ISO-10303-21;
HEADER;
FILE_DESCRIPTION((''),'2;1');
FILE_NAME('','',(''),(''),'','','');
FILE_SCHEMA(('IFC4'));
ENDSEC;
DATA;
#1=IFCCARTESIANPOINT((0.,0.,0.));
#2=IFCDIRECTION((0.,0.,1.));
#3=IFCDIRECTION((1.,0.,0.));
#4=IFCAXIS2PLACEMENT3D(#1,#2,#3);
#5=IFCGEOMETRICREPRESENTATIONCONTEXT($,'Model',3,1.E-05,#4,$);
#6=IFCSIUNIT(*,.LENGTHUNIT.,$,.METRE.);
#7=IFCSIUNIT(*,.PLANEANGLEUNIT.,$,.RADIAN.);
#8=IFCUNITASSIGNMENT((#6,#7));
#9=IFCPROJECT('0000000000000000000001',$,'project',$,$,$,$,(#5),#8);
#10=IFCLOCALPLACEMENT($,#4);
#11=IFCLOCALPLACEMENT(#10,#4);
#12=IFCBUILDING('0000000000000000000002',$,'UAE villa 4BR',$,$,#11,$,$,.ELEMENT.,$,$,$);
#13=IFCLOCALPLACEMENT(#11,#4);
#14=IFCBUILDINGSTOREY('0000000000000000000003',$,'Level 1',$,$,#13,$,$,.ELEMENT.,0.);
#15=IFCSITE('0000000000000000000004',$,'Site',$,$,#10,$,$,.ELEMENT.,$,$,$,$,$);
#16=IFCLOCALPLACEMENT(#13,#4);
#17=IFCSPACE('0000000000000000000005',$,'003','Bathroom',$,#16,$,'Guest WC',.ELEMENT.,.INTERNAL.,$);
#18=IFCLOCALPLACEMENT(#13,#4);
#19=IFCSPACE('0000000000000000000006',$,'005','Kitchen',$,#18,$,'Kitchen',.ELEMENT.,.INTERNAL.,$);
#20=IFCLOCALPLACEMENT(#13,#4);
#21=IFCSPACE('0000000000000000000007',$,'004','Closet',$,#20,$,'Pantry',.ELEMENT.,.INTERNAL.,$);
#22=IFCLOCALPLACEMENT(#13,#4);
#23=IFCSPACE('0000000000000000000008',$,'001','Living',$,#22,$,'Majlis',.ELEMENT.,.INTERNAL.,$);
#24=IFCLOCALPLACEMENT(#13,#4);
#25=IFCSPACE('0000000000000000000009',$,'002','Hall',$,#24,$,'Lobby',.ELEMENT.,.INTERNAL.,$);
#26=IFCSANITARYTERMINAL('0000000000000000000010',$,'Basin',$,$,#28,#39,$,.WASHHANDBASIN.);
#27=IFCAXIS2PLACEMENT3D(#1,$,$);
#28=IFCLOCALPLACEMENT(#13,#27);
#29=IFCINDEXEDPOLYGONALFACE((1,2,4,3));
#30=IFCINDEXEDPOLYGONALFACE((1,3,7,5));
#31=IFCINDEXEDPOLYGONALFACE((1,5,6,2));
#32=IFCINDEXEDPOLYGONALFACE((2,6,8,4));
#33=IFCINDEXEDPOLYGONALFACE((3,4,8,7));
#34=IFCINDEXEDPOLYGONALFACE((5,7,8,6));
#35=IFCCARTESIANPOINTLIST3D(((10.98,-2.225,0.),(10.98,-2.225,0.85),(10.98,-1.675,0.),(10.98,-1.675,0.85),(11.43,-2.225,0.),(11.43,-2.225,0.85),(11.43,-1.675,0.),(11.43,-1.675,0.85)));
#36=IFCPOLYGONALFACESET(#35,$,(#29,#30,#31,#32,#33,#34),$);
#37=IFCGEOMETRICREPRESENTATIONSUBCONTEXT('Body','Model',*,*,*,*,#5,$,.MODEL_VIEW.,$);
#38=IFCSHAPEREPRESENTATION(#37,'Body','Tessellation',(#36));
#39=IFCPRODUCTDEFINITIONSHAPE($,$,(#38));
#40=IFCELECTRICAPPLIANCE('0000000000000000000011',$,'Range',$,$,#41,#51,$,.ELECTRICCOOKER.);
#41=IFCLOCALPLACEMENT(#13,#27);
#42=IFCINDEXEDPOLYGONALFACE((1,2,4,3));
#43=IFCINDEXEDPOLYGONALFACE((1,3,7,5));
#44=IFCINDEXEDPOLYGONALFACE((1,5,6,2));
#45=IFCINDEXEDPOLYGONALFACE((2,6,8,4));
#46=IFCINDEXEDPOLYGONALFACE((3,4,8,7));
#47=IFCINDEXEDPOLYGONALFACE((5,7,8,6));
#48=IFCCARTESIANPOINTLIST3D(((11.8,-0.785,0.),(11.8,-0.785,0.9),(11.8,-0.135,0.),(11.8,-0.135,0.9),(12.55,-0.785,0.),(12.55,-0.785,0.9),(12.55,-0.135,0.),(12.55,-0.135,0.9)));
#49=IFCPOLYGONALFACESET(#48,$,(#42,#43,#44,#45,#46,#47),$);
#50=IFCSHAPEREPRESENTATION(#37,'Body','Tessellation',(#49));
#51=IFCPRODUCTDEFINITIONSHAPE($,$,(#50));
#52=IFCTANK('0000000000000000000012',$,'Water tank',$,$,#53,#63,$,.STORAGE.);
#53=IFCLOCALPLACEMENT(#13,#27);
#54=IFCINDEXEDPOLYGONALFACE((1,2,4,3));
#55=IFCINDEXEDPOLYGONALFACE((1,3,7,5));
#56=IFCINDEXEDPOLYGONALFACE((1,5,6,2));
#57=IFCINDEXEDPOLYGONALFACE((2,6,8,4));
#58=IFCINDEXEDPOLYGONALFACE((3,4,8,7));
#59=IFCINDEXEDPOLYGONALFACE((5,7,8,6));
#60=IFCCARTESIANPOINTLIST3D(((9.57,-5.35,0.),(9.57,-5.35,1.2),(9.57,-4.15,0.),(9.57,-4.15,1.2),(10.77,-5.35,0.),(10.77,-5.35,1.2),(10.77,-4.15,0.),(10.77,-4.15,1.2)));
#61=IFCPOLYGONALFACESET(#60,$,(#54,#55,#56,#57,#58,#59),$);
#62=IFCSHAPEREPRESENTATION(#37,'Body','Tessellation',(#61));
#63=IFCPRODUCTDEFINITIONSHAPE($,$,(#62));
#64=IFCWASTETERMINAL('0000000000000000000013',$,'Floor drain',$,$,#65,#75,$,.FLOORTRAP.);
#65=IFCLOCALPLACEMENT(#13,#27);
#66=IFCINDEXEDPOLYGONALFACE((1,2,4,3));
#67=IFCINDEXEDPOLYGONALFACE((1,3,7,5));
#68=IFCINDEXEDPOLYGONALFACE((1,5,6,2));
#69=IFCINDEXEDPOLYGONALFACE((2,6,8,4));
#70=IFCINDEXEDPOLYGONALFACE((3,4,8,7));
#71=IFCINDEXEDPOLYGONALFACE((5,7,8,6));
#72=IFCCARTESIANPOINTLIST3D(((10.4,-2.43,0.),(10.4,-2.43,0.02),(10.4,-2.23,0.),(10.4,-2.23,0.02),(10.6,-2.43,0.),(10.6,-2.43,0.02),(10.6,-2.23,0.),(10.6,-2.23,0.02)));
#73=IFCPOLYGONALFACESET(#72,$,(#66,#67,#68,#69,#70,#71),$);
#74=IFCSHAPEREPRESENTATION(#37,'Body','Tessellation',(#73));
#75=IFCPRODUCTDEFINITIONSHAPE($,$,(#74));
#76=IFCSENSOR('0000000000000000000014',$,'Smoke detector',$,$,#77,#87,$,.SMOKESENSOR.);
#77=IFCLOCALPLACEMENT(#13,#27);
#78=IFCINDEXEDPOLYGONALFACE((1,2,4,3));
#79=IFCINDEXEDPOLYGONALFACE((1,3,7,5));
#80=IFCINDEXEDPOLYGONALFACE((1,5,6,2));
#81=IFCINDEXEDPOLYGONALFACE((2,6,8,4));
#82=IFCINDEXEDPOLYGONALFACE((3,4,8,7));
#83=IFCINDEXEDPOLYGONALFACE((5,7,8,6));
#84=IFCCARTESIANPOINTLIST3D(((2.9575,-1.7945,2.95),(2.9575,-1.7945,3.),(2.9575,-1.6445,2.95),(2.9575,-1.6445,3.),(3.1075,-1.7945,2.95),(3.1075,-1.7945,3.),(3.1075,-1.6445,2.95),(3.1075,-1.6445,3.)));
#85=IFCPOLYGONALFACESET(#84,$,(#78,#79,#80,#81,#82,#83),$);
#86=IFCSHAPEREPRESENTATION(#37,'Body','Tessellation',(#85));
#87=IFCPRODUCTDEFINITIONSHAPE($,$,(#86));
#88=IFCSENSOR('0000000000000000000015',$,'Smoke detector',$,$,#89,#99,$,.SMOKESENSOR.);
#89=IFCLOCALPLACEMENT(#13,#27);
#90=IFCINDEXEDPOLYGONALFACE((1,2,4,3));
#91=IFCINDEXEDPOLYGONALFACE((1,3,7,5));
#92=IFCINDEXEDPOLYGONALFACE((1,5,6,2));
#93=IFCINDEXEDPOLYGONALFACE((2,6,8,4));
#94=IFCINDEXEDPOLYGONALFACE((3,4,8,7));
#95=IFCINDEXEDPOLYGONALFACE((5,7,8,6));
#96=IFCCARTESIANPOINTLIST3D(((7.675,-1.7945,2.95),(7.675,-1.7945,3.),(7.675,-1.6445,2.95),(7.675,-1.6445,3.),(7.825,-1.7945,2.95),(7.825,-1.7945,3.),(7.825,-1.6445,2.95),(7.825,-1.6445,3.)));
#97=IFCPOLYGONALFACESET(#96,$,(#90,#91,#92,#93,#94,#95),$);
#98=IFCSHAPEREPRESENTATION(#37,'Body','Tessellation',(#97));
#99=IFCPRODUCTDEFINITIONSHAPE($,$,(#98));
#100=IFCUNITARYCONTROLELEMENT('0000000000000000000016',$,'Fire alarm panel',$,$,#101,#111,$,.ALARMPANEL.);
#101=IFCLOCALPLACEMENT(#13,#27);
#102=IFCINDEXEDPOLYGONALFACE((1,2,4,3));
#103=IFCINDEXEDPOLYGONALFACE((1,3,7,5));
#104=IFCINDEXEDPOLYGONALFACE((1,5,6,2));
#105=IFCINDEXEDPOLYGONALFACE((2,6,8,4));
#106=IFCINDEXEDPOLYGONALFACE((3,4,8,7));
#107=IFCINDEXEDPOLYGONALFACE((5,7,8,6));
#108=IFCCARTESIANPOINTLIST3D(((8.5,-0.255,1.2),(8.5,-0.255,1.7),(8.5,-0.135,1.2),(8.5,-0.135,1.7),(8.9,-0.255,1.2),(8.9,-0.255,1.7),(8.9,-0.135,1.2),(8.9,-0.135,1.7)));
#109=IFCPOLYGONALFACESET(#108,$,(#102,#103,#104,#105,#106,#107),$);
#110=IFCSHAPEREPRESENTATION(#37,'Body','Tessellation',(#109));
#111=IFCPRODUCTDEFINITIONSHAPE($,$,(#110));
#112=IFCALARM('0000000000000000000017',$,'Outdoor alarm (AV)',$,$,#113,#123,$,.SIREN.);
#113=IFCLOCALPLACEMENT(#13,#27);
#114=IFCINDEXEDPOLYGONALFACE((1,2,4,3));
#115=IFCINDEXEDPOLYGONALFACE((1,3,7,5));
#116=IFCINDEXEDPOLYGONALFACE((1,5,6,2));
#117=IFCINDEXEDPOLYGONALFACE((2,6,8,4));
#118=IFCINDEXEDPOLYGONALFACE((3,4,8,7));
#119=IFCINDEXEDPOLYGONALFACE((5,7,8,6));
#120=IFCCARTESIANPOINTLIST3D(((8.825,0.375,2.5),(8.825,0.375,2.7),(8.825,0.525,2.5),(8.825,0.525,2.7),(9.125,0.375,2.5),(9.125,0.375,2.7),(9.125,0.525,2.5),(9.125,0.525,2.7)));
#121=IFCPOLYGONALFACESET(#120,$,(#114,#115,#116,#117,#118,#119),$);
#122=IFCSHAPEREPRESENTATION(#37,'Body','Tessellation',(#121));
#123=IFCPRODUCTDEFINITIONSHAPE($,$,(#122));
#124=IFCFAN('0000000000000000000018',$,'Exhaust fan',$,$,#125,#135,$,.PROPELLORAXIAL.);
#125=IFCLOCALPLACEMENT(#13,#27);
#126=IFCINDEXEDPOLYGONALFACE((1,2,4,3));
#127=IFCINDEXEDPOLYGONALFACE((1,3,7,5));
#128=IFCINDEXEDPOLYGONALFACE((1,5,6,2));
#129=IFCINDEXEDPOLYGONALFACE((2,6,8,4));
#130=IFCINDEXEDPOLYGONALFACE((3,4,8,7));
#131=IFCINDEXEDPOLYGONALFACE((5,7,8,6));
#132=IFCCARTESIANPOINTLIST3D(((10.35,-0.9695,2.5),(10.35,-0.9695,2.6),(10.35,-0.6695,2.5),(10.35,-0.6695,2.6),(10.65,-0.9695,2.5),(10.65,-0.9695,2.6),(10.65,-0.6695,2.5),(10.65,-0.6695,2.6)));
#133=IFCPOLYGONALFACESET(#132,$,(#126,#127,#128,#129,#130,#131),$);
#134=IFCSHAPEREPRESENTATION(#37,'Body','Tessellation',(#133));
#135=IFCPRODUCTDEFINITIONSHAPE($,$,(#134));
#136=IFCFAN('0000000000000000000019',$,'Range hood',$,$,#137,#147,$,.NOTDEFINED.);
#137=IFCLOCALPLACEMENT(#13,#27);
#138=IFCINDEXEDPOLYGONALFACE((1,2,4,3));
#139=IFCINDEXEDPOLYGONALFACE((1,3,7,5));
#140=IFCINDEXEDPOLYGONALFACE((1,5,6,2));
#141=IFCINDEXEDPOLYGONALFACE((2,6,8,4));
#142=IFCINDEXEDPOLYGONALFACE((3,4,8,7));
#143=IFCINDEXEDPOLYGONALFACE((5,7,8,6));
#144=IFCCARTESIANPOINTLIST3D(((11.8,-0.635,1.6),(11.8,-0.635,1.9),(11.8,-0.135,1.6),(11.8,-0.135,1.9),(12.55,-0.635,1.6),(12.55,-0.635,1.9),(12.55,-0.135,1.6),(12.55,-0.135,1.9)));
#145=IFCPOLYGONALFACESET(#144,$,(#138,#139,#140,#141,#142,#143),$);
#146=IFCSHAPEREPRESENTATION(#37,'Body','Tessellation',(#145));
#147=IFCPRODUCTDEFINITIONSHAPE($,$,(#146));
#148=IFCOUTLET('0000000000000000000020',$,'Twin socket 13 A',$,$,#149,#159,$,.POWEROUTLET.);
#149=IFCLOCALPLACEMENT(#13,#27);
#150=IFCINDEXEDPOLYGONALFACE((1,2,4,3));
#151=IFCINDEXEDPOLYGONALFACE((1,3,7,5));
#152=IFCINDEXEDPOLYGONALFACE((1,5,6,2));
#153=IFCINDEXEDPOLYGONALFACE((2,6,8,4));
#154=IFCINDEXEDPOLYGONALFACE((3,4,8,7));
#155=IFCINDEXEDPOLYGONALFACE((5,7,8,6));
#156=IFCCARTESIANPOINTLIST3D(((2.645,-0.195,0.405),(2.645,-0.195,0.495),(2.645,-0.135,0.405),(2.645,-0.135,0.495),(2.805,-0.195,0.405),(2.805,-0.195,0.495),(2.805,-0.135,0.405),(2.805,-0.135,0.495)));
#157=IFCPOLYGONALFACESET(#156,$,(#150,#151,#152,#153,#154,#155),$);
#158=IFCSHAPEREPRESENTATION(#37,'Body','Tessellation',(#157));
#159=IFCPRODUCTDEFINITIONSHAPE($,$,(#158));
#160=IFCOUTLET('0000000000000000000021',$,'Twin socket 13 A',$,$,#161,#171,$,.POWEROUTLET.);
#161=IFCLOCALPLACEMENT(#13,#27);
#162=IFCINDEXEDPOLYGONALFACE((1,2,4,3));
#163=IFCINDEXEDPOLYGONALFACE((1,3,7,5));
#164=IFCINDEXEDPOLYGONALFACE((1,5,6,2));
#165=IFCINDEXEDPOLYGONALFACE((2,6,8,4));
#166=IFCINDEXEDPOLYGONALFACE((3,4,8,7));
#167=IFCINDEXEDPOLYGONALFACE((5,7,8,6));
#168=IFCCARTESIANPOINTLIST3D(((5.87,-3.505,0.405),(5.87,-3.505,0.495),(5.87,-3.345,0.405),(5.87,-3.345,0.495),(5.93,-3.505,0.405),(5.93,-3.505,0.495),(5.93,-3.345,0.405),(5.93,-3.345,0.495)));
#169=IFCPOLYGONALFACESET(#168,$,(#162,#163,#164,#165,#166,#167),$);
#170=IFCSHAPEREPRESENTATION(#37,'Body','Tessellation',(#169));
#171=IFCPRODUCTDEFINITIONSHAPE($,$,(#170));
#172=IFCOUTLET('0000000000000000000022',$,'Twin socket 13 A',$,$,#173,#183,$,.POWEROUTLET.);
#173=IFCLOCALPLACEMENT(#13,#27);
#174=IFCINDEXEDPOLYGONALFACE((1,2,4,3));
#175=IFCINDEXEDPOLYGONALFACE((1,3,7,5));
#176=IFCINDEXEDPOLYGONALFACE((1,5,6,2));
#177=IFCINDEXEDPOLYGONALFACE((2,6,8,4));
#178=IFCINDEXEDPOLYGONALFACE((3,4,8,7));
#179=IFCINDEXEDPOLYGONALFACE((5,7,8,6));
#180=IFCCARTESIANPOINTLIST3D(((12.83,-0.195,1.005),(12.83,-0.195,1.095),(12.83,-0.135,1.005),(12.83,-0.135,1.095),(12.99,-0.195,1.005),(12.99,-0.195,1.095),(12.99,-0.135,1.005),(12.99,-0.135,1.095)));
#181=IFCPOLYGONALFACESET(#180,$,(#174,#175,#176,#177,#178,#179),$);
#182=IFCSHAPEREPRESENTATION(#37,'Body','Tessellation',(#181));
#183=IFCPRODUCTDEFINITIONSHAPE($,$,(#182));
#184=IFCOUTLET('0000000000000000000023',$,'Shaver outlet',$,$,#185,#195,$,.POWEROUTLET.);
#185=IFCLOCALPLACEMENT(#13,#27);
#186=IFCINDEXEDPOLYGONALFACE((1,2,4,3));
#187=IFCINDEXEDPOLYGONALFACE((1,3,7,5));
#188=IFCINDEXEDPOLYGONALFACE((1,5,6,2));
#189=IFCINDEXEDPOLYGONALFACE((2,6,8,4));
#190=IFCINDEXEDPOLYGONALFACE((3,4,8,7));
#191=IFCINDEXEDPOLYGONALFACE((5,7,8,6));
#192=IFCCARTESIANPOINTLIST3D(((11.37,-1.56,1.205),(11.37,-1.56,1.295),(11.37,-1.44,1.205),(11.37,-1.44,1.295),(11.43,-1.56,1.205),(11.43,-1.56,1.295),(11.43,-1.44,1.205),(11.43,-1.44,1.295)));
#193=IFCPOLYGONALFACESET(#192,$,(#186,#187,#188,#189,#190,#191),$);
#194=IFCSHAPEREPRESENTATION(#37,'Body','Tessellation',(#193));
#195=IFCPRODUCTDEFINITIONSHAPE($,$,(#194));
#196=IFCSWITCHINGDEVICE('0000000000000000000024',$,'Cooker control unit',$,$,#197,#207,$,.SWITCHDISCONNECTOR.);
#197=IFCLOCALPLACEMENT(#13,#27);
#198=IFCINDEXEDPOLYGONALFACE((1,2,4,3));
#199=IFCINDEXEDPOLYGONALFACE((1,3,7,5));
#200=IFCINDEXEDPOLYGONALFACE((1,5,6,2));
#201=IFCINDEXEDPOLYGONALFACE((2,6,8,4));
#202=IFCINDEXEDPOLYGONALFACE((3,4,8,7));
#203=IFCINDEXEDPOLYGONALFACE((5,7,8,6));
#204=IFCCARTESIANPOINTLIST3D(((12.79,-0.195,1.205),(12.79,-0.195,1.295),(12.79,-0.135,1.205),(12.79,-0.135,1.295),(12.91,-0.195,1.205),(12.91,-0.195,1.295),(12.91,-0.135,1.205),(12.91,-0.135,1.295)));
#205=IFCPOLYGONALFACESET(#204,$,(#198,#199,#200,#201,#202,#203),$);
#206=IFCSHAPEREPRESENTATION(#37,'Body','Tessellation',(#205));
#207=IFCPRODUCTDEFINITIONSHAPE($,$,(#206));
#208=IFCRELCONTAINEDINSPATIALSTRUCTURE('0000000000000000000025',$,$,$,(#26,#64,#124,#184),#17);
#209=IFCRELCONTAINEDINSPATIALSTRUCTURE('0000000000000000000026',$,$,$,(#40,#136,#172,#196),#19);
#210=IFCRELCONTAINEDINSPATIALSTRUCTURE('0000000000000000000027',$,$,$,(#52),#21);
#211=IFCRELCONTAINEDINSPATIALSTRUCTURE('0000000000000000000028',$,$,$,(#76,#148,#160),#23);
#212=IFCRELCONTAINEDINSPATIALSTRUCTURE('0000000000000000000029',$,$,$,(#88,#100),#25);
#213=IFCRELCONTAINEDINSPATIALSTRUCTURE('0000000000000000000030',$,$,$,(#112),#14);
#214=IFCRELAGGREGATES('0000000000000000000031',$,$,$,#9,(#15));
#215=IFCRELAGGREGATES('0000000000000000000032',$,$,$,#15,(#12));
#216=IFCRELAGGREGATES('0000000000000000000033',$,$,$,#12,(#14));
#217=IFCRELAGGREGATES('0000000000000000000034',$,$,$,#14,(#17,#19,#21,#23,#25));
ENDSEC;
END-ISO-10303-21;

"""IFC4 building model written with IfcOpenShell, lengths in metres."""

from ifc_helpers import new_model, si_unit, frame, origin, origin_with_axes, origin_2d, place, context, subcontext, project, spatial, rectangle, extrude, element, save


model = new_model("IFC4")

# Units and contexts
model_context = context("Model", 3, precision=1e-05, world=origin_with_axes())
body_context = subcontext(model_context, "Body", "Model", "MODEL_VIEW")
ifc_project = project(units=[si_unit("LENGTHUNIT", "METRE"), si_unit("PLANEANGLEUNIT", "RADIAN")], contexts=[model_context])

# Site, building, storey
site_placement = place(None, origin_with_axes())
site = spatial("IfcSite", under=ifc_project, at=site_placement, Name="Site", CompositionType="ELEMENT")
building_placement = place(site_placement, origin_with_axes())
building = spatial("IfcBuilding", under=site, at=building_placement, Name="UAE villa 4BR", CompositionType="ELEMENT")
storey_placement = place(building_placement, origin_with_axes())
storey = spatial("IfcBuildingStorey", under=building, at=storey_placement, Name="Level 1", CompositionType="ELEMENT", Elevation=0.0)

# Shared definitions
space_1_placement = place(storey_placement, origin_with_axes())
space_1 = spatial("IfcSpace", under=storey, at=space_1_placement, Name="003", Description="Bathroom", LongName="Guest WC", CompositionType="ELEMENT", PredefinedType="INTERNAL")

# Sanitary terminal
sanitary_terminal_1_placement = place(storey_placement, frame((11.205, -1.95, 0.0), z_axis=(0.0, 0.0, 1.0), x_axis=(0.0, -1.0, 0.0)))
element("IfcSanitaryTerminal", 1, at=sanitary_terminal_1_placement, inside=space_1, Name="Basin", PredefinedType="WASHHANDBASIN", context=body_context, shape_type="SweptSolid", body=[
    extrude(rectangle(XDim=0.55, YDim=0.45, at=origin_2d()), origin(), (0.0, 0.0, 1.0), 0.85),
])

# Shared definitions
space_2_placement = place(storey_placement, origin_with_axes())
space_2 = spatial("IfcSpace", under=storey, at=space_2_placement, Name="005", Description="Kitchen", LongName="Kitchen", CompositionType="ELEMENT", PredefinedType="INTERNAL")

# Electric appliance
electric_appliance_placement = place(storey_placement, frame((12.175, -0.46, 0.0), z_axis=(0.0, 0.0, 1.0), x_axis=(1.0, 0.0, 0.0)))
element("IfcElectricAppliance", 2, at=electric_appliance_placement, inside=space_2, Name="Range", PredefinedType="ELECTRICCOOKER", context=body_context, shape_type="SweptSolid", body=[
    extrude(rectangle(XDim=0.75, YDim=0.65, at=origin_2d()), origin(), (0.0, 0.0, 1.0), 0.9),
])

# Shared definitions
space_3_placement = place(storey_placement, origin_with_axes())
space_3 = spatial("IfcSpace", under=storey, at=space_3_placement, Name="004", Description="Closet", LongName="Pantry", CompositionType="ELEMENT", PredefinedType="INTERNAL")

# Tank
tank_placement = place(storey_placement, frame((10.17, -4.75, 0.0), z_axis=(0.0, 0.0, 1.0), x_axis=(0.0, 1.0, 0.0)))
element("IfcTank", 3, at=tank_placement, inside=space_3, Name="Water tank", PredefinedType="STORAGE", context=body_context, shape_type="SweptSolid", body=[
    extrude(rectangle(XDim=1.2, YDim=1.2, at=origin_2d()), origin(), (0.0, 0.0, 1.0), 1.2),
])

# Waste terminal
waste_terminal_placement = place(storey_placement, frame((10.5, -2.33, 0.0), z_axis=(0.0, 0.0, 1.0), x_axis=(-1.0, 0.0, 0.0)))
element("IfcWasteTerminal", 4, at=waste_terminal_placement, inside=space_1, Name="Floor drain", PredefinedType="FLOORTRAP", context=body_context, shape_type="SweptSolid", body=[
    extrude(rectangle(XDim=0.2, YDim=0.2, at=origin_2d()), origin(), (0.0, 0.0, 1.0), 0.02),
])

# Shared definitions
space_4_placement = place(storey_placement, origin_with_axes())
space_4 = spatial("IfcSpace", under=storey, at=space_4_placement, Name="001", Description="Living", LongName="Majlis", CompositionType="ELEMENT", PredefinedType="INTERNAL")

# Sensor
sensor_1_placement = place(storey_placement, frame((3.0325, -1.7195, 2.95), z_axis=(0.0, 0.0, 1.0), x_axis=(1.0, 0.0, 0.0)))
element("IfcSensor", 5, at=sensor_1_placement, inside=space_4, Name="Smoke detector", PredefinedType="SMOKESENSOR", context=body_context, shape_type="SweptSolid", body=[
    extrude(rectangle(XDim=0.15, YDim=0.15, at=origin_2d()), origin(), (0.0, 0.0, 1.0), 0.05),
])

# Shared definitions
space_5_placement = place(storey_placement, origin_with_axes())
space_5 = spatial("IfcSpace", under=storey, at=space_5_placement, Name="002", Description="Hall", LongName="Lobby", CompositionType="ELEMENT", PredefinedType="INTERNAL")

# Sensor
sensor_2_placement = place(storey_placement, frame((7.75, -1.7195, 2.95), z_axis=(0.0, 0.0, 1.0), x_axis=(1.0, 0.0, 0.0)))
element("IfcSensor", 6, at=sensor_2_placement, inside=space_5, Name="Smoke detector", PredefinedType="SMOKESENSOR", context=body_context, shape_type="SweptSolid", body=[
    extrude(rectangle(XDim=0.15, YDim=0.15, at=origin_2d()), origin(), (0.0, 0.0, 1.0), 0.05),
])

# Unitary control element
unitary_control_element_placement = place(storey_placement, frame((8.7, -0.195, 1.2), z_axis=(0.0, 0.0, 1.0), x_axis=(1.0, 0.0, 0.0)))
element("IfcUnitaryControlElement", 7, at=unitary_control_element_placement, inside=space_5, Name="Fire alarm panel", PredefinedType="ALARMPANEL", context=body_context, shape_type="SweptSolid", body=[
    extrude(rectangle(XDim=0.4, YDim=0.12, at=origin_2d()), origin(), (0.0, 0.0, 1.0), 0.5),
])

# Alarm
alarm_placement = place(storey_placement, frame((8.975, 0.45, 2.5), z_axis=(0.0, 0.0, 1.0), x_axis=(-1.0, 0.0, 0.0)))
element("IfcAlarm", 8, at=alarm_placement, inside=storey, Name="Outdoor alarm (AV)", PredefinedType="SIREN", context=body_context, shape_type="SweptSolid", body=[
    extrude(rectangle(XDim=0.3, YDim=0.15, at=origin_2d()), origin(), (0.0, 0.0, 1.0), 0.2),
])

# Fans
fan_1_placement = place(storey_placement, frame((10.5, -0.8195, 2.5), z_axis=(0.0, 0.0, 1.0), x_axis=(1.0, 0.0, 0.0)))
element("IfcFan", 9, at=fan_1_placement, inside=space_1, Name="Exhaust fan", PredefinedType="PROPELLORAXIAL", context=body_context, shape_type="SweptSolid", body=[
    extrude(rectangle(XDim=0.3, YDim=0.3, at=origin_2d()), origin(), (0.0, 0.0, 1.0), 0.1),
])
fan_2_placement = place(storey_placement, frame((12.175, -0.385, 1.6), z_axis=(0.0, 0.0, 1.0), x_axis=(1.0, 0.0, 0.0)))
element("IfcFan", 10, at=fan_2_placement, inside=space_2, Name="Range hood", PredefinedType="NOTDEFINED", context=body_context, shape_type="SweptSolid", body=[
    extrude(rectangle(XDim=0.75, YDim=0.5, at=origin_2d()), origin(), (0.0, 0.0, 1.0), 0.3),
])

# Outlets
for number, where, z_axis, x_axis, name in (
    (11, (2.725, -0.165, 0.405), (0.0, 0.0, 1.0), (1.0, 0.0, 0.0), "Twin socket 13 A"),
    (12, (5.9, -3.425, 0.405), (0.0, 0.0, 1.0), (0.0, -1.0, 0.0), "Twin socket 13 A"),
):
    element("IfcOutlet", number, at=place(storey_placement, frame(where, z_axis=z_axis, x_axis=x_axis)), inside=space_4, Name=name, PredefinedType="POWEROUTLET", context=body_context, shape_type="SweptSolid", body=[
        extrude(rectangle(XDim=0.16, YDim=0.06, at=origin_2d()), origin(), (0.0, 0.0, 1.0), 0.09),
    ])
outlet_1_placement = place(storey_placement, frame((12.91, -0.165, 1.005), z_axis=(0.0, 0.0, 1.0), x_axis=(1.0, 0.0, 0.0)))
element("IfcOutlet", 13, at=outlet_1_placement, inside=space_2, Name="Twin socket 13 A", PredefinedType="POWEROUTLET", context=body_context, shape_type="SweptSolid", body=[
    extrude(rectangle(XDim=0.16, YDim=0.06, at=origin_2d()), origin(), (0.0, 0.0, 1.0), 0.09),
])
outlet_2_placement = place(storey_placement, frame((11.4, -1.5, 1.205), z_axis=(0.0, 0.0, 1.0), x_axis=(0.0, -1.0, 0.0)))
element("IfcOutlet", 14, at=outlet_2_placement, inside=space_1, Name="Shaver outlet", PredefinedType="POWEROUTLET", context=body_context, shape_type="SweptSolid", body=[
    extrude(rectangle(XDim=0.12, YDim=0.06, at=origin_2d()), origin(), (0.0, 0.0, 1.0), 0.09),
])

# Switching device
switching_device_placement = place(storey_placement, frame((12.85, -0.165, 1.205), z_axis=(0.0, 0.0, 1.0), x_axis=(1.0, 0.0, 0.0)))
element("IfcSwitchingDevice", 15, at=switching_device_placement, inside=space_2, Name="Cooker control unit", PredefinedType="SWITCHDISCONNECTOR", context=body_context, shape_type="SweptSolid", body=[
    extrude(rectangle(XDim=0.12, YDim=0.06, at=origin_2d()), origin(), (0.0, 0.0, 1.0), 0.09),
])

save(model, "model.ifc")
